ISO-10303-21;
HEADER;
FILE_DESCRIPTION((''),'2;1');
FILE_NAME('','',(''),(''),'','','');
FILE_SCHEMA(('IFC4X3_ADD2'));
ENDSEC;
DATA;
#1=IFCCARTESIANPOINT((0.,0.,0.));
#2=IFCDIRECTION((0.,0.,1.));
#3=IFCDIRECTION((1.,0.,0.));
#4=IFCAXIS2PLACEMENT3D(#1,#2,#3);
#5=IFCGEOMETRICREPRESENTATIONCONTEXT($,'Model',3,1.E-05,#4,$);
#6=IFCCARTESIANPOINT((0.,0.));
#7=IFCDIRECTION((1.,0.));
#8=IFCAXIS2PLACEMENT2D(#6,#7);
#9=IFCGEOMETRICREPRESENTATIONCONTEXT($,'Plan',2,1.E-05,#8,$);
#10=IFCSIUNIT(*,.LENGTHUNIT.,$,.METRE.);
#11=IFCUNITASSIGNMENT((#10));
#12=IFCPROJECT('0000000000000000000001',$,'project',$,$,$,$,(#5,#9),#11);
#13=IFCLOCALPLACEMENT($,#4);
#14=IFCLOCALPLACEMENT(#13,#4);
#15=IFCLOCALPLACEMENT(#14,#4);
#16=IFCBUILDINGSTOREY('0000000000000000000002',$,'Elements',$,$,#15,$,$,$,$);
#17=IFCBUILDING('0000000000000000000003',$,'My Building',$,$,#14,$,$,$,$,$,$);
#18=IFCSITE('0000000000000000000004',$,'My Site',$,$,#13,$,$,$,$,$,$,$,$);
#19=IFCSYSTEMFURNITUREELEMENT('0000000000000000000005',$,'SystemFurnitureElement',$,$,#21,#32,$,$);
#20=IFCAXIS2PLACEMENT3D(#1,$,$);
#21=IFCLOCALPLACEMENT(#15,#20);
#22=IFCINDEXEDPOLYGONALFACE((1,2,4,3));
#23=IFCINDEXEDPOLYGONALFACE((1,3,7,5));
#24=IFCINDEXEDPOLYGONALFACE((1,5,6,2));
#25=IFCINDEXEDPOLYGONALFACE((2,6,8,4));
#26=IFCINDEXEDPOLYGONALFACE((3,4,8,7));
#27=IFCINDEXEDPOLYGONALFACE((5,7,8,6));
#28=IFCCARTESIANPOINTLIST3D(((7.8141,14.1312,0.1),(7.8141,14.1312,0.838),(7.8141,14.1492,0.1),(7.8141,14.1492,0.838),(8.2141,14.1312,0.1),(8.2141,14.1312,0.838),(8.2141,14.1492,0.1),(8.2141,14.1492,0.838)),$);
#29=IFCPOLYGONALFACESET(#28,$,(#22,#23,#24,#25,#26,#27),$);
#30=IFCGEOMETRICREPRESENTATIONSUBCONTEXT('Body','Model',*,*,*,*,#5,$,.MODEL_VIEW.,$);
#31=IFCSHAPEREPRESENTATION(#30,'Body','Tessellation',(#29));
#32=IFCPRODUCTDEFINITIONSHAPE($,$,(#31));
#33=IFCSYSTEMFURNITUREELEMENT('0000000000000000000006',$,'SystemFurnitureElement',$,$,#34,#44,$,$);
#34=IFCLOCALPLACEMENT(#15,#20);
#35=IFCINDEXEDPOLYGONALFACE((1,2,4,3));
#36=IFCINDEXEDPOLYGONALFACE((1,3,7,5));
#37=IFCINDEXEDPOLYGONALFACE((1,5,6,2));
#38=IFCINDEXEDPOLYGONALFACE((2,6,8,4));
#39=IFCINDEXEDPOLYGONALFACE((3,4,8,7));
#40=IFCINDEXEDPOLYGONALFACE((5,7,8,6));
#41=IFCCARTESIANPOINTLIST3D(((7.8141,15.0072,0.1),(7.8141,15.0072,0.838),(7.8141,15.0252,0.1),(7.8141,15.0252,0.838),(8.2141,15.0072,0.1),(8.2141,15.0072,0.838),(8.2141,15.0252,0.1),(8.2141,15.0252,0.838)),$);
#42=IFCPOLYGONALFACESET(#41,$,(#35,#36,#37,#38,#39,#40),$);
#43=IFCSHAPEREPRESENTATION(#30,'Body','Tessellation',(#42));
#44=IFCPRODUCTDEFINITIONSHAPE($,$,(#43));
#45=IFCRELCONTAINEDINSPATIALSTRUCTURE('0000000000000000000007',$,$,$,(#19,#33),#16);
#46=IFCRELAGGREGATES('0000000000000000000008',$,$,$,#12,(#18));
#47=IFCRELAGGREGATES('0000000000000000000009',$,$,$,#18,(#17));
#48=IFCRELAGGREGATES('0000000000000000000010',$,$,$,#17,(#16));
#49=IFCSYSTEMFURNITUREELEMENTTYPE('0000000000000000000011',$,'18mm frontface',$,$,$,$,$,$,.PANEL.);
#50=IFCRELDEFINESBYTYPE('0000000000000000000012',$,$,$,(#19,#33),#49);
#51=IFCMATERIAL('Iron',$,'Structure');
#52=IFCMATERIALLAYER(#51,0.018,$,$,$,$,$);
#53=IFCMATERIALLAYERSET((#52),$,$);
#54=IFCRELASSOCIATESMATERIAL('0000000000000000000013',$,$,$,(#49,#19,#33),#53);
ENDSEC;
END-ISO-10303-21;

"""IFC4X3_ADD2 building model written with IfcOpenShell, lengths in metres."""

from ifc_helpers import new_model, si_unit, frame, origin_with_axes, origin_2d_with_axis, place, context, subcontext, project, spatial, line, indexed_curve, outline, extrude, material, layer, layer_set, layer_usage, type_object, element, save


model = new_model("IFC4X3_ADD2")

# Units and contexts
model_context = context("Model", 3, precision=1e-05, world=origin_with_axes())
plan_context = context("Plan", 2, precision=1e-05, world=origin_2d_with_axis())
body_context = subcontext(model_context, "Body", "Model", "MODEL_VIEW")
ifc_project = project(units=[si_unit("LENGTHUNIT", "METRE")], contexts=[model_context, plan_context])

# Site, building, storey
site_placement = place(None, origin_with_axes())
site = spatial("IfcSite", under=ifc_project, at=site_placement, Name="My Site")
building_placement = place(site_placement, origin_with_axes())
building = spatial("IfcBuilding", under=site, at=building_placement, Name="My Building")
storey_placement = place(building_placement, origin_with_axes())
storey = spatial("IfcBuildingStorey", under=building, at=storey_placement, Name="Elements")

# Shared definitions
ifc_material_1 = material(Name="Iron", Category="Structure")

# System furniture elements
ifc_layer_1 = layer(ifc_material_1, 0.018)
ifc_layer_set_1 = layer_set([ifc_layer_1])
ifc_layer_usage_1 = layer_usage(ifc_layer_set_1, "AXIS2", "POSITIVE", 0.0)
system_furniture_element_type_1 = type_object("IfcSystemFurnitureElementType", Name="18mm frontface", PredefinedType="PANEL", material=ifc_layer_set_1)
system_furniture_element_1_placement = place(storey_placement, frame((8.2141, 14.1492, 0.1), z_axis=(0.0, 0.0, 1.0), x_axis=(-1.0, 0.0, 0.0)))
element("IfcSystemFurnitureElement", 1, at=system_furniture_element_1_placement, inside=storey, type_object=system_furniture_element_type_1, material=ifc_layer_usage_1, Name="SystemFurnitureElement", context=body_context, shape_type="SweptSolid", body=[
    extrude(outline(indexed_curve([(0.0, 0.0), (0.0, 0.018), (0.4, 0.018), (0.4, 0.0)], segments=[line(1, 2, 3, 4, 1)])), origin_with_axes(), (0.0, 0.0, 1.0), 0.738),
])
ifc_layer_usage_2 = layer_usage(ifc_layer_set_1, "AXIS2", "POSITIVE", 0.0)
system_furniture_element_2_placement = place(storey_placement, frame((8.2141, 15.0252, 0.1), z_axis=(0.0, 0.0, 1.0), x_axis=(-1.0, 0.0, 0.0)))
element("IfcSystemFurnitureElement", 2, at=system_furniture_element_2_placement, inside=storey, type_object=system_furniture_element_type_1, material=ifc_layer_usage_2, Name="SystemFurnitureElement", context=body_context, shape_type="SweptSolid", body=[
    extrude(outline(indexed_curve([(0.0, 0.0), (0.0, 0.018), (0.4, 0.018), (0.4, 0.0)], segments=[line(1, 2, 3, 4, 1)])), origin_with_axes(), (0.0, 0.0, 1.0), 0.738),
])

save(model, "model.ifc")
